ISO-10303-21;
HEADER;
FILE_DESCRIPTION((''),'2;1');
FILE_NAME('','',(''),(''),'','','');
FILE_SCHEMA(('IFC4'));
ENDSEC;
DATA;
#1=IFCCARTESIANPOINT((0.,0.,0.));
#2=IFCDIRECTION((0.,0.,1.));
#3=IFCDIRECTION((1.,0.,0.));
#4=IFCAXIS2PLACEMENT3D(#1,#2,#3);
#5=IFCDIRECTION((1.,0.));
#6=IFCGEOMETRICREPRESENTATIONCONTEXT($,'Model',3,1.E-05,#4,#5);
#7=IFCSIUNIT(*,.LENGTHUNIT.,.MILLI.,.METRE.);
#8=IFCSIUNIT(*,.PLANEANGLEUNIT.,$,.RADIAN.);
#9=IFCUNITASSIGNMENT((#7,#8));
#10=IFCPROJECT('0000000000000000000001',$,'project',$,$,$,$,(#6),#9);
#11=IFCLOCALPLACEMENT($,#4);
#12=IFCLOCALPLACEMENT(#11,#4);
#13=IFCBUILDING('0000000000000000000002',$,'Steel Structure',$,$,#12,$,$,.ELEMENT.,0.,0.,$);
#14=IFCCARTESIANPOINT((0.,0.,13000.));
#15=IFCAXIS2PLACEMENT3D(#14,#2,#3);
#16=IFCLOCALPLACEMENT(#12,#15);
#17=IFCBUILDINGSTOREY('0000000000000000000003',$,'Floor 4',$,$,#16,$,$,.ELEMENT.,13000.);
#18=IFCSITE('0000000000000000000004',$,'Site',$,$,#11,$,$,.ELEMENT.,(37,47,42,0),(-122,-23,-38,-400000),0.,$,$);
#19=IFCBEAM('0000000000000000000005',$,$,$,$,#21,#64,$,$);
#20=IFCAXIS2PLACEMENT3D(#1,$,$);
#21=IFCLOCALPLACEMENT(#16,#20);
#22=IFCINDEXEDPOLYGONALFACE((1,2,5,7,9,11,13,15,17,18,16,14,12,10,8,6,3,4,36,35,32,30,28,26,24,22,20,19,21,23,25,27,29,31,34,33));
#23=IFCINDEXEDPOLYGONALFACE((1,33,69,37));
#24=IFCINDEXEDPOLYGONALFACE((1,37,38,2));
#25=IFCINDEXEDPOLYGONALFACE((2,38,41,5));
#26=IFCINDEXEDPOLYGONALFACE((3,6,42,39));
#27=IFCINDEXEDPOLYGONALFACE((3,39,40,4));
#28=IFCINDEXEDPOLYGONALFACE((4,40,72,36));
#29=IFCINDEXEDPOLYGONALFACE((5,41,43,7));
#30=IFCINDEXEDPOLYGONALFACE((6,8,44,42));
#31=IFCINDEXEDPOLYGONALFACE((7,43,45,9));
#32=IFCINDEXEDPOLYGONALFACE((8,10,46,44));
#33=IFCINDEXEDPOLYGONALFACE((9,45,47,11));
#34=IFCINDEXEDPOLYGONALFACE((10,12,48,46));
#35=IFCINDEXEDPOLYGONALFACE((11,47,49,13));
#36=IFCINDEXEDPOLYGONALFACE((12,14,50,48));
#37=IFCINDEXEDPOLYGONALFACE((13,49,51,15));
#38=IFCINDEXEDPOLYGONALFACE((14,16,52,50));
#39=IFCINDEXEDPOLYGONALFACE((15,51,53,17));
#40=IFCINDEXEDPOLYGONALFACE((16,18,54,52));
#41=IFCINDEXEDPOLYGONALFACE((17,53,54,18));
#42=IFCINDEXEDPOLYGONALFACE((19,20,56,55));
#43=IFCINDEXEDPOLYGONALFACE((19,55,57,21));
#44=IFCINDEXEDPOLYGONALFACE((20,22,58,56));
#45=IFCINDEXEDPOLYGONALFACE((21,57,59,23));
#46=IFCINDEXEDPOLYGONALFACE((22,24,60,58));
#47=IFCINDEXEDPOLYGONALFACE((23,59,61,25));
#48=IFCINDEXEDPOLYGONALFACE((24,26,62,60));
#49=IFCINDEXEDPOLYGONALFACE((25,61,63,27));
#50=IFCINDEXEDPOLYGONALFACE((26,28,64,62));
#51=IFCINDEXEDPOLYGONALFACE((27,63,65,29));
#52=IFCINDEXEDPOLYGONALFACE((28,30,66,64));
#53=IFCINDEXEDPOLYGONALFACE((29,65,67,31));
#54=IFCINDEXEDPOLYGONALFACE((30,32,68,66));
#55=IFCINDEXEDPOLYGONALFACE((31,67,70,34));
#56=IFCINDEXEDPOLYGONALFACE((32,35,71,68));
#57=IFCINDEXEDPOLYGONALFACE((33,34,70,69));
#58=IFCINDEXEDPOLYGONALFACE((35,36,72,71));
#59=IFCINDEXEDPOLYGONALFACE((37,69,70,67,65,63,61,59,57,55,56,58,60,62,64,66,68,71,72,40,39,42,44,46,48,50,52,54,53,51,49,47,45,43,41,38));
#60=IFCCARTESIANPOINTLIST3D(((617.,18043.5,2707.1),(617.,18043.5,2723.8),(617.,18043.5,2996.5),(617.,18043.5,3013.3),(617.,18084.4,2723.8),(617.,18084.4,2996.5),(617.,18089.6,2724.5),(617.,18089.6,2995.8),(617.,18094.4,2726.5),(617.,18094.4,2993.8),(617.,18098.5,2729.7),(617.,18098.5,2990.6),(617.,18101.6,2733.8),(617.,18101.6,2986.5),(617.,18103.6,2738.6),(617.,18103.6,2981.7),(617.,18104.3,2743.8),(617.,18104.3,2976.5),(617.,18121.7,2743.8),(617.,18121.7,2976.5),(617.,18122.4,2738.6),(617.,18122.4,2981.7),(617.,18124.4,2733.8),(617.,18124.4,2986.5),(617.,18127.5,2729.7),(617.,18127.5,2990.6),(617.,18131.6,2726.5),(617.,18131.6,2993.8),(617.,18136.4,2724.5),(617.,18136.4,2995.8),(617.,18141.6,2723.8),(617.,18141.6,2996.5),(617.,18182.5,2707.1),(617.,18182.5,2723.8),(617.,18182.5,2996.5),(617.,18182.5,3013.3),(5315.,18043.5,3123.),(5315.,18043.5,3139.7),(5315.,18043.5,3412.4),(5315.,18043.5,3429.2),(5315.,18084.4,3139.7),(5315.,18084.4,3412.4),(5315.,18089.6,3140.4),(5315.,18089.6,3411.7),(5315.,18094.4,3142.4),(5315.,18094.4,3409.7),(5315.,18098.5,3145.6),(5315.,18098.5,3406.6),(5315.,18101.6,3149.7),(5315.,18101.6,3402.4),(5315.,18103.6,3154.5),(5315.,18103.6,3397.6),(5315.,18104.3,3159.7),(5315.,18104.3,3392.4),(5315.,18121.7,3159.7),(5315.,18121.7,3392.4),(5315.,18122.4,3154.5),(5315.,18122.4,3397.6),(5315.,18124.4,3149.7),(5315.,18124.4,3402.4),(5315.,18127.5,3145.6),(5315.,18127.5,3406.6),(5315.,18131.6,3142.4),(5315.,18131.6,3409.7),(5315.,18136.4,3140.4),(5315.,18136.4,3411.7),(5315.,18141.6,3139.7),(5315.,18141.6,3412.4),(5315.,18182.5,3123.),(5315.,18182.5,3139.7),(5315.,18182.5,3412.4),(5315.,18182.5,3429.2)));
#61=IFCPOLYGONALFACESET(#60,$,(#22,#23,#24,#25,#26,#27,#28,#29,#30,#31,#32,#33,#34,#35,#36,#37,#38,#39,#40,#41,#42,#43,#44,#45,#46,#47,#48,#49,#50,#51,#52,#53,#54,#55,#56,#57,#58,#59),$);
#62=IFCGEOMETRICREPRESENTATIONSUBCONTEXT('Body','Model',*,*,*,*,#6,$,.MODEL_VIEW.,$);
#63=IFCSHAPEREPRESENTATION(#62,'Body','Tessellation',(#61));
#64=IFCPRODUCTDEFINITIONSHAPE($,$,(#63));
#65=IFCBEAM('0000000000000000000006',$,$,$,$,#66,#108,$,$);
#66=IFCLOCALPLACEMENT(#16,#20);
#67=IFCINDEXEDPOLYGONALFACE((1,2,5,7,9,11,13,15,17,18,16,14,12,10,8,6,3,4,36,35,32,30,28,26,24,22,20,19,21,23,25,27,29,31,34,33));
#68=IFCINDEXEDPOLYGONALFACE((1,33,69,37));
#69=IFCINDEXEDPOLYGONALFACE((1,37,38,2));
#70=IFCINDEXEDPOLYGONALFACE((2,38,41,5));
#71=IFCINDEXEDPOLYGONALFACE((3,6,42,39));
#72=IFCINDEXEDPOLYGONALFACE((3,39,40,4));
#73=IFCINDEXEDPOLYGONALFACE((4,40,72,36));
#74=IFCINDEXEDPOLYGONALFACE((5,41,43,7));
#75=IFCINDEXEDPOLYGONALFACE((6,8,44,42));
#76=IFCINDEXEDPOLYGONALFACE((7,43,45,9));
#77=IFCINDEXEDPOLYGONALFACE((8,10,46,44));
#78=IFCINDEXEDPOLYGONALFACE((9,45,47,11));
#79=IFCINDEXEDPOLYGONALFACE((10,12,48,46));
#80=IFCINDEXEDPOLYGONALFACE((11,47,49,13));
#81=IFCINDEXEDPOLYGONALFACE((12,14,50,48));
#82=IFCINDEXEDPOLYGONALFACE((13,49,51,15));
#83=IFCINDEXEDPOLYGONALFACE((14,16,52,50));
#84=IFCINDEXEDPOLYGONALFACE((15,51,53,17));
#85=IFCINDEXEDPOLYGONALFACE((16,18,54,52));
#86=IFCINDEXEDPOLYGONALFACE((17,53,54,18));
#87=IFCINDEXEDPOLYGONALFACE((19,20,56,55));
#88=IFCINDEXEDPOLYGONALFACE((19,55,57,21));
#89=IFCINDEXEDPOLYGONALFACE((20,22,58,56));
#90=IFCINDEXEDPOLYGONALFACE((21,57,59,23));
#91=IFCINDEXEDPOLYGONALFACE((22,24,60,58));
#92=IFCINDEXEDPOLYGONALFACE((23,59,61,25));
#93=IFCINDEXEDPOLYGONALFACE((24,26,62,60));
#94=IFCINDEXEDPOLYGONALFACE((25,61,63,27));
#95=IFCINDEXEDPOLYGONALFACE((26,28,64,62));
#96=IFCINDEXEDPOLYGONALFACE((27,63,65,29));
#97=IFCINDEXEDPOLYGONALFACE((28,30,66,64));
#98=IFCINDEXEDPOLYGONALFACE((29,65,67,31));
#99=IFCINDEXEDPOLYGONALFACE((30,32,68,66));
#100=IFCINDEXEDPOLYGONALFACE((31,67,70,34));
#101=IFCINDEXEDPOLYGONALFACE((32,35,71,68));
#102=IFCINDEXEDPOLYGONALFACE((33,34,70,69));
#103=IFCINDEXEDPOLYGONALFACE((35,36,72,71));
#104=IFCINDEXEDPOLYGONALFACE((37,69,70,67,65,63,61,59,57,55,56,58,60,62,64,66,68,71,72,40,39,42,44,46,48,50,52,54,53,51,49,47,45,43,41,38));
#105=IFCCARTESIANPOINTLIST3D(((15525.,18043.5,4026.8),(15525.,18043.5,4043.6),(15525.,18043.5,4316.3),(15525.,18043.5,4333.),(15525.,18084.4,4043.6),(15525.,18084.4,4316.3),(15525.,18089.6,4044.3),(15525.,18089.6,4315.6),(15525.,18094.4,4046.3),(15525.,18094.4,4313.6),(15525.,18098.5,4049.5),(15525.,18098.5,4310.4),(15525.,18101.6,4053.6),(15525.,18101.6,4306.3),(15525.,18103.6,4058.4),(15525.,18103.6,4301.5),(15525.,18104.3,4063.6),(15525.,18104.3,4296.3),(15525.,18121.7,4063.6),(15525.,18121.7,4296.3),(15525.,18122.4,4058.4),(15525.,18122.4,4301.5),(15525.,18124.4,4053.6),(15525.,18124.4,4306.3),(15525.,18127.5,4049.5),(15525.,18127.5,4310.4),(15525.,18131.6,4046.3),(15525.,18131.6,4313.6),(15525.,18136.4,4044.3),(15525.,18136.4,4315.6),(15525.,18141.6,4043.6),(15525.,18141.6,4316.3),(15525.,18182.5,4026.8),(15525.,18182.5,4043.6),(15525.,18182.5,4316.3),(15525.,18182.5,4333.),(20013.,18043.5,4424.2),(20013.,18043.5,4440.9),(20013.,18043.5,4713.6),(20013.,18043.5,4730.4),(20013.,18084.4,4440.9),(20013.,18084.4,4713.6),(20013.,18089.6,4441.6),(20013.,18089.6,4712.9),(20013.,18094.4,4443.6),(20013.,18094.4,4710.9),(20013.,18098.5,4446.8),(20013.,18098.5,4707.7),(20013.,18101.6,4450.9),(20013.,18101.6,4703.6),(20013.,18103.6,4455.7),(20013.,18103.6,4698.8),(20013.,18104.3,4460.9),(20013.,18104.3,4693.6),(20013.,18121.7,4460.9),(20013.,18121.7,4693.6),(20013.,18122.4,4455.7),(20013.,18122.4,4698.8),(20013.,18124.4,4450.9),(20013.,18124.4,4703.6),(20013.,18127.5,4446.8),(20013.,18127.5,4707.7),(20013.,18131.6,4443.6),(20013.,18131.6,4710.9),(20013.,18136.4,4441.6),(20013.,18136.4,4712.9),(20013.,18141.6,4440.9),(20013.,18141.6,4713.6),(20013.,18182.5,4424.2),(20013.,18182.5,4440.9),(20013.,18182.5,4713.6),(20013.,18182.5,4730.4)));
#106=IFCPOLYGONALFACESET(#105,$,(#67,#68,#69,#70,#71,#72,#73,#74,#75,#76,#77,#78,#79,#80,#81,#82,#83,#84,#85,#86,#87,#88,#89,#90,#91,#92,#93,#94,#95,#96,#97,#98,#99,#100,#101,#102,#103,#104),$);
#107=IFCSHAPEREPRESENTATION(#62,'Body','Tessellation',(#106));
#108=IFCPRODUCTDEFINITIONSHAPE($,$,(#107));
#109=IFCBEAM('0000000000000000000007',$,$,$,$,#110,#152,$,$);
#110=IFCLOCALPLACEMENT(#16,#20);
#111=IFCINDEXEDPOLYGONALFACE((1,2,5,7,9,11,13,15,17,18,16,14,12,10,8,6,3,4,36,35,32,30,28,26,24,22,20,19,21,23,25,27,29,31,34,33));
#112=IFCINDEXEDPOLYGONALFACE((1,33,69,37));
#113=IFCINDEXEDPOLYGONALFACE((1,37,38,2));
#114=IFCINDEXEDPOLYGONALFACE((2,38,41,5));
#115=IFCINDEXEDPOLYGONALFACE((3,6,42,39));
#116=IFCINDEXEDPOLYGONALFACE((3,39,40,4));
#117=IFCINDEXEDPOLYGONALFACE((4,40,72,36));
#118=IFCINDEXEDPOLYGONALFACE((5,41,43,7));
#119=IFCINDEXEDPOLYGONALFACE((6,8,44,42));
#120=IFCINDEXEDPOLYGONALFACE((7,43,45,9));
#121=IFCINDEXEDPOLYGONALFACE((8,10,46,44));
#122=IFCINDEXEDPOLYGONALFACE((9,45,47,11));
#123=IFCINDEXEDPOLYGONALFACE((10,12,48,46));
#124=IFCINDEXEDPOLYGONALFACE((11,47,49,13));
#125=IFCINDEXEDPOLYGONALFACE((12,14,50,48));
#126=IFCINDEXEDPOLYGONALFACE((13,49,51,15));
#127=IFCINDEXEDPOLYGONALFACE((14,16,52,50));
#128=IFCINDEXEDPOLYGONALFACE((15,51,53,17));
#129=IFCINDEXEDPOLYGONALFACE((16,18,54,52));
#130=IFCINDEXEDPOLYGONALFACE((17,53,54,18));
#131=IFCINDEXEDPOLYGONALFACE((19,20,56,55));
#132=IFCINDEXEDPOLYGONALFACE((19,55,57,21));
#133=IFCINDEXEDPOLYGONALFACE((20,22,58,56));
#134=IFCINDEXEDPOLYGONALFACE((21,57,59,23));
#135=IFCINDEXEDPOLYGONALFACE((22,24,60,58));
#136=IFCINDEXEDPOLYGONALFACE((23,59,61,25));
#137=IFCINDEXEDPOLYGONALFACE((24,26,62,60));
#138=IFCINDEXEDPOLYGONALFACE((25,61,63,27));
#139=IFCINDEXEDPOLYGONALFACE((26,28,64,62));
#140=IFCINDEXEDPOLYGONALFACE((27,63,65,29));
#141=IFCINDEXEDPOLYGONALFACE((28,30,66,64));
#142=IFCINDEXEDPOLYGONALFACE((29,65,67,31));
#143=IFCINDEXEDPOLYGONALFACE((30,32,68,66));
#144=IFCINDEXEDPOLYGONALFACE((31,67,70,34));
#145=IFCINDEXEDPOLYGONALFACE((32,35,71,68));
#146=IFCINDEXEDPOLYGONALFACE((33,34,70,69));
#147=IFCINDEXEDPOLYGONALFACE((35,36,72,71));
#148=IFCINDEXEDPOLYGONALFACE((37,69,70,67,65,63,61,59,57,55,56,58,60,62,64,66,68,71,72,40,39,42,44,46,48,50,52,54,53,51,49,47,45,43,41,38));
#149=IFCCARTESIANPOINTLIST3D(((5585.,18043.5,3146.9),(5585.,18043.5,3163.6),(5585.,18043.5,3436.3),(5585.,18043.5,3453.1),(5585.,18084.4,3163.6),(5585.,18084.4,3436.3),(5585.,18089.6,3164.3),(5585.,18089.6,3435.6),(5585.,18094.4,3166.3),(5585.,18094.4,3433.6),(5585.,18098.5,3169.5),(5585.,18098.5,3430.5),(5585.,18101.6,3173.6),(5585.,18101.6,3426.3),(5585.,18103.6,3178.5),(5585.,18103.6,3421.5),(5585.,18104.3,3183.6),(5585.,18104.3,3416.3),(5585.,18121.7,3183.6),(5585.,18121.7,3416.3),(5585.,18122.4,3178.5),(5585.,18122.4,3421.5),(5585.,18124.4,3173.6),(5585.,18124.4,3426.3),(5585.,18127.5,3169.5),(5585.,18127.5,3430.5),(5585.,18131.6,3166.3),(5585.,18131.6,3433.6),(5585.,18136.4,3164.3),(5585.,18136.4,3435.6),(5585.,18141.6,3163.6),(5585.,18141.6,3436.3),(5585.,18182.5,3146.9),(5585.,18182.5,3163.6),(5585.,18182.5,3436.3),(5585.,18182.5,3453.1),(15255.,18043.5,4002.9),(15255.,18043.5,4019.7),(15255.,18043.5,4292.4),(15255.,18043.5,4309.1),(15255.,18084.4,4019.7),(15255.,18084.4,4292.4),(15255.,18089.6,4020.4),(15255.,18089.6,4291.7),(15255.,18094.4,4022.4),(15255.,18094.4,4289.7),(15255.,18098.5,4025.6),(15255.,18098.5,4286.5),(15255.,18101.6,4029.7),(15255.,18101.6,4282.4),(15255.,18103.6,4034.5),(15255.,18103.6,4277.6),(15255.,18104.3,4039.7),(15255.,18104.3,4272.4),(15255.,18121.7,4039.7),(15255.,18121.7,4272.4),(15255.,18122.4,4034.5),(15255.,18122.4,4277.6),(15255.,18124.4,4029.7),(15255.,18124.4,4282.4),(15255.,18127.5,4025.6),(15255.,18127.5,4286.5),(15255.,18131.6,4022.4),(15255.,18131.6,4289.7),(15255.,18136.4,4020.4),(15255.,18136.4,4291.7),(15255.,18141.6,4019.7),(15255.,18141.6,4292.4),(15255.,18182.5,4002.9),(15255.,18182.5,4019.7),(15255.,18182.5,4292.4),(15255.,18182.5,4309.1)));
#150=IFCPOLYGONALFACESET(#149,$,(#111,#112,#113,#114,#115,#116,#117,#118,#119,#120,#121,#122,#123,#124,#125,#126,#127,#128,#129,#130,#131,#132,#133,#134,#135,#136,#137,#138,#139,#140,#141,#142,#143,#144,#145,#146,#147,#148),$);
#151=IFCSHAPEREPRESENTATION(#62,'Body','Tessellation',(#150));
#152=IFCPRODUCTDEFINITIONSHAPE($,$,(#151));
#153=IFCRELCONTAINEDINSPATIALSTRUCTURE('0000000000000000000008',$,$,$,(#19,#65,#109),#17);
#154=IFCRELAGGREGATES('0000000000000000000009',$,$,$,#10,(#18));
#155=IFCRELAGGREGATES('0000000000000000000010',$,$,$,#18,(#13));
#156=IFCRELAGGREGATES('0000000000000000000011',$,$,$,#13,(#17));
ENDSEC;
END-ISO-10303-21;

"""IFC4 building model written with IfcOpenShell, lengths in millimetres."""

from ifc_helpers import new_model, si_unit, direction, frame, origin_with_axes, origin_2d_with_axis, place, context, subcontext, project, spatial, polyline, i_section, extrude, clip, bounded_halfspace, element, save


model = new_model("IFC4")

# Units and contexts
model_context = context("Model", 3, precision=1e-05, world=origin_with_axes(), true_north=direction((1.0, 0.0)))
body_context = subcontext(model_context, "Body", "Model", "MODEL_VIEW")
ifc_project = project(units=[si_unit("LENGTHUNIT", "METRE", prefix="MILLI"), si_unit("PLANEANGLEUNIT", "RADIAN")], contexts=[model_context])

# Site, building, storey
site_placement = place(None, origin_with_axes())
site = spatial("IfcSite", under=ifc_project, at=site_placement, Name="Site", CompositionType="ELEMENT", RefLatitude=(37, 47, 42, 0), RefLongitude=(-122, -23, -38, -400000), RefElevation=0.0)
building_placement = place(site_placement, origin_with_axes())
building = spatial("IfcBuilding", under=site, at=building_placement, Name="Steel Structure", CompositionType="ELEMENT", ElevationOfRefHeight=0.0, ElevationOfTerrain=0.0)
storey_placement = place(building_placement, frame((0.0, 0.0, 13000.0), z_axis=(0.0, 0.0, 1.0), x_axis=(1.0, 0.0, 0.0)))
storey = spatial("IfcBuildingStorey", under=building, at=storey_placement, Name="Floor 4", CompositionType="ELEMENT", Elevation=13000.0)

# Beams
beam_1_placement = place(storey_placement, frame((617.0, 18113.0, 2707.1), z_axis=(0.996104, 0.0, 0.088184), x_axis=(0.0, 1.0, 0.0)))
element("IfcBeam", 1, at=beam_1_placement, inside=storey, context=body_context, shape_type="Clipping", body=[
    clip(clip(extrude(i_section(OverallWidth=139.0, OverallDepth=305.0, WebThickness=17.4, FlangeThickness=16.7, FilletRadius=19.9, at=origin_2d_with_axis()), frame((0.0, 152.5, 0.0), z_axis=(0.0, 0.0, 1.0), x_axis=(1.0, 0.0, 0.0)), (0.0, 0.0, 1.0), 4743.4), bounded_halfspace(frame((-18113.0, -15645.9, -1385.1), z_axis=(0.0, 0.088184, -0.996104), x_axis=(-1.0, 0.0, 0.0)), False, frame((0.0, 152.5, 0.0), z_axis=(0.0, 0.0, 1.0), x_axis=(1.0, 0.0, 0.0)), polyline([(69.5, 152.5), (69.5, 135.8), (28.6, 135.8), (8.7, 115.9), (8.7, -115.9), (28.6, -135.8), (69.5, -135.8), (69.5, -152.5), (-69.5, -152.5), (-69.5, -135.8), (-28.6, -135.8), (-8.7, -115.9), (-8.7, 115.9), (-28.6, 135.8), (-69.5, 135.8), (-69.5, 152.5), (69.5, 152.5)]))), bounded_halfspace(frame((-18113.0, -16060.2, 3294.6), z_axis=(0.0, -0.088184, 0.996104), x_axis=(1.0, 0.0, 0.0)), False, frame((0.0, 152.5, 0.0), z_axis=(0.0, 0.0, 1.0), x_axis=(1.0, 0.0, 0.0)), polyline([(-69.5, -135.8), (-69.5, -152.5), (69.5, -152.5), (69.5, -135.8), (28.6, -135.8), (8.7, -115.9), (8.7, 115.9), (28.6, 135.8), (69.5, 135.8), (69.5, 152.5), (-69.5, 152.5), (-69.5, 135.8), (-28.6, 135.8), (-8.7, 115.9), (-8.7, -115.9), (-28.6, -135.8), (-69.5, -135.8)]))),
])
beam_2_placement = place(storey_placement, frame((15525.0, 18113.0, 4026.8), z_axis=(0.996104, 0.0, 0.088184), x_axis=(0.0, 1.0, 0.0)))
element("IfcBeam", 2, at=beam_2_placement, inside=storey, context=body_context, shape_type="Clipping", body=[
    clip(clip(extrude(i_section(OverallWidth=139.0, OverallDepth=305.0, WebThickness=17.4, FlangeThickness=16.7, FilletRadius=19.9, at=origin_2d_with_axis()), frame((0.0, 152.5, 0.0), z_axis=(0.0, 0.0, 1.0), x_axis=(1.0, 0.0, 0.0)), (0.0, 0.0, 1.0), 4532.6), bounded_halfspace(frame((-18113.0, -16960.5, -1501.5), z_axis=(0.0, 0.088184, -0.996104), x_axis=(-1.0, 0.0, 0.0)), False, frame((0.0, 152.5, 0.0), z_axis=(0.0, 0.0, 1.0), x_axis=(1.0, 0.0, 0.0)), polyline([(-69.5, -152.5), (-69.5, -135.8), (-28.6, -135.8), (-8.7, -115.9), (-8.7, 115.9), (-28.6, 135.8), (-69.5, 135.8), (-69.5, 152.5), (69.5, 152.5), (69.5, 135.8), (28.6, 135.8), (8.7, 115.9), (8.7, -115.9), (28.6, -135.8), (69.5, -135.8), (69.5, -152.5), (-69.5, -152.5)]))), bounded_halfspace(frame((-18113.0, -17356.3, 2969.1), z_axis=(0.0, -0.088184, 0.996104), x_axis=(1.0, 0.0, 0.0)), False, frame((0.0, 152.5, 0.0), z_axis=(0.0, 0.0, 1.0), x_axis=(1.0, 0.0, 0.0)), polyline([(69.5, 135.8), (69.5, 152.5), (-69.5, 152.5), (-69.5, 135.8), (-28.6, 135.8), (-8.7, 115.9), (-8.7, -115.9), (-28.6, -135.8), (-69.5, -135.8), (-69.5, -152.5), (69.5, -152.5), (69.5, -135.8), (28.6, -135.8), (8.7, -115.9), (8.7, 115.9), (28.6, 135.8), (69.5, 135.8)]))),
])
beam_3_placement = place(storey_placement, frame((5585.0, 18113.0, 3146.9), z_axis=(0.996104, 0.0, 0.088184), x_axis=(0.0, 1.0, 0.0)))
element("IfcBeam", 3, at=beam_3_placement, inside=storey, context=body_context, shape_type="Clipping", body=[
    clip(clip(extrude(i_section(OverallWidth=139.0, OverallDepth=305.0, WebThickness=17.4, FlangeThickness=16.7, FilletRadius=19.9, at=origin_2d_with_axis()), frame((0.0, 152.5, 0.0), z_axis=(0.0, 0.0, 1.0), x_axis=(1.0, 0.0, 0.0)), (0.0, 0.0, 1.0), 9734.8), bounded_halfspace(frame((-18113.0, -16084.0, -1423.9), z_axis=(0.0, 0.088184, -0.996104), x_axis=(-1.0, 0.0, 0.0)), False, frame((0.0, 152.5, 0.0), z_axis=(0.0, 0.0, 1.0), x_axis=(1.0, 0.0, 0.0)), polyline([(69.5, 152.5), (69.5, 135.8), (28.6, 135.8), (8.7, 115.9), (8.7, -115.9), (28.6, -135.8), (69.5, -135.8), (69.5, -152.5), (-69.5, -152.5), (-69.5, -135.8), (-28.6, -135.8), (-8.7, -115.9), (-8.7, 115.9), (-28.6, 135.8), (-69.5, 135.8), (-69.5, 152.5), (69.5, 152.5)]))), bounded_halfspace(frame((-18113.0, -16936.7, 8208.4), z_axis=(0.0, -0.088184, 0.996104), x_axis=(1.0, 0.0, 0.0)), False, frame((0.0, 152.5, 0.0), z_axis=(0.0, 0.0, 1.0), x_axis=(1.0, 0.0, 0.0)), polyline([(69.5, 135.8), (69.5, 152.5), (-69.5, 152.5), (-69.5, 135.8), (-28.6, 135.8), (-8.7, 115.9), (-8.7, -115.9), (-28.6, -135.8), (-69.5, -135.8), (-69.5, -152.5), (69.5, -152.5), (69.5, -135.8), (28.6, -135.8), (8.7, -115.9), (8.7, 115.9), (28.6, 135.8), (69.5, 135.8)]))),
])

save(model, "model.ifc")
